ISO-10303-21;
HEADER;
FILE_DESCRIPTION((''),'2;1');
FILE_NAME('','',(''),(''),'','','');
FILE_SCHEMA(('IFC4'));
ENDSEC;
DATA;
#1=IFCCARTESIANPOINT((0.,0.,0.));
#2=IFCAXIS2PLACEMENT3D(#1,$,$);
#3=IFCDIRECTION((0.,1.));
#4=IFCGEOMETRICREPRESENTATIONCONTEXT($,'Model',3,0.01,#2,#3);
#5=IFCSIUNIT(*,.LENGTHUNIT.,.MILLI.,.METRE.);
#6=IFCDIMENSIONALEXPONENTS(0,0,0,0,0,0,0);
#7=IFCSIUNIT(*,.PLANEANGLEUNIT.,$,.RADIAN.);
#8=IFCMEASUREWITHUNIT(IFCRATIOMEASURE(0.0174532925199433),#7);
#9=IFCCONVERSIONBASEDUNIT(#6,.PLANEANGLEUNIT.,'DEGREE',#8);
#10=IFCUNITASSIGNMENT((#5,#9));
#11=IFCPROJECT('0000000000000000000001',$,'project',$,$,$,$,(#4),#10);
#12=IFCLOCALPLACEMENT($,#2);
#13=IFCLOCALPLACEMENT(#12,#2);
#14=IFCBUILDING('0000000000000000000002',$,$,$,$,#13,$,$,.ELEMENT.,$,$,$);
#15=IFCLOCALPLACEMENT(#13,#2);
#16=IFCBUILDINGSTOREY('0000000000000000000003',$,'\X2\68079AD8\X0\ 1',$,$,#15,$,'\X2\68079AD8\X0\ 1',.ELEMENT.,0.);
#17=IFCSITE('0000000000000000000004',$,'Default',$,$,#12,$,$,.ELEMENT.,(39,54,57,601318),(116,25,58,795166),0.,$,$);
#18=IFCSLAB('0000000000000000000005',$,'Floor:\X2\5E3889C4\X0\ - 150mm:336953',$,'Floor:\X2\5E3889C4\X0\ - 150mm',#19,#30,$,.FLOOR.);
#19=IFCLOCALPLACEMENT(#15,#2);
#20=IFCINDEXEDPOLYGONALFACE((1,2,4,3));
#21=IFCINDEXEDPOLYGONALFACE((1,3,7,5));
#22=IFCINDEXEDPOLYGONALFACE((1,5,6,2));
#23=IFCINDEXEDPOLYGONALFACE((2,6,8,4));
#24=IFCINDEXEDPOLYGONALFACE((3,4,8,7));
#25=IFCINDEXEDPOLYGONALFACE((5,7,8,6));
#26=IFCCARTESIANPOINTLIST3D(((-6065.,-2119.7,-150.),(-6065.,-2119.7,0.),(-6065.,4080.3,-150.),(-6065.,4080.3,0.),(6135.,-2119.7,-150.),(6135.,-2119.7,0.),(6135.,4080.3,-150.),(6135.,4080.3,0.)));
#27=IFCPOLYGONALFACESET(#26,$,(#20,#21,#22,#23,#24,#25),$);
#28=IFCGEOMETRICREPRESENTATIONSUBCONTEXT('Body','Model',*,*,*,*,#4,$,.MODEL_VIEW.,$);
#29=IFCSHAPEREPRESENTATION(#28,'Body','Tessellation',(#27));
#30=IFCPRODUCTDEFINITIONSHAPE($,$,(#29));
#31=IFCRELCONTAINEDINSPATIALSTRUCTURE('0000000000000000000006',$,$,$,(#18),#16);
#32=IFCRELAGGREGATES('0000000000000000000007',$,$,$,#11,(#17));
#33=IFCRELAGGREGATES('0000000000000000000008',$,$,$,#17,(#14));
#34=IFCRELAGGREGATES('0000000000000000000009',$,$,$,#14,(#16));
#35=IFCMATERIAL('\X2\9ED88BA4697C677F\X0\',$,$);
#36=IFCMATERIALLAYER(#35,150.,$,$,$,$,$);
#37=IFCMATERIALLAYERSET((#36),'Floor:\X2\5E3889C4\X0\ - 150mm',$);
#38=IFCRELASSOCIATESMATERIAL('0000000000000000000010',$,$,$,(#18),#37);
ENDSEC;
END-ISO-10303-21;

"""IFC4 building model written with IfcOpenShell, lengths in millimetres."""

from ifc_helpers import new_model, entity, si_unit, converted_unit, direction, frame, origin, origin_2d_with_axis, place, context, subcontext, project, spatial, rectangle, extrude, material, layer, layer_set, layer_usage, element, save


model = new_model("IFC4")

# Units and contexts
model_context = context("Model", 3, precision=0.01, world=origin(), true_north=direction((0.0, 1.0)))
body_context = subcontext(model_context, "Body", "Model", "MODEL_VIEW")
ifc_project = project(units=[si_unit("LENGTHUNIT", "METRE", prefix="MILLI"), converted_unit("PLANEANGLEUNIT", "DEGREE", entity("IfcRatioMeasure", 0.0174532925199433), si_unit("PLANEANGLEUNIT", "RADIAN"), dimensions=[0, 0, 0, 0, 0, 0, 0])], contexts=[model_context])

# Site, building, storey
site_placement = place(None, origin())
site = spatial("IfcSite", under=ifc_project, at=site_placement, Name="Default", CompositionType="ELEMENT", RefLatitude=(39, 54, 57, 601318), RefLongitude=(116, 25, 58, 795166), RefElevation=0.0)
building_placement = place(site_placement, origin())
building = spatial("IfcBuilding", under=site, at=building_placement, CompositionType="ELEMENT")
storey_placement = place(building_placement, origin())
storey = spatial("IfcBuildingStorey", under=building, at=storey_placement, Name="标高 1", LongName="标高 1", CompositionType="ELEMENT", Elevation=0.0)

# Slab
ifc_material = material(Name="默认楼板")
ifc_layer = layer(ifc_material, 150.0)
ifc_layer_set = layer_set([ifc_layer], Name="Floor:常规 - 150mm")
ifc_layer_usage = layer_usage(ifc_layer_set, "AXIS3", "POSITIVE", 0.0)
slab_placement = place(storey_placement, origin())
element("IfcSlab", 1, at=slab_placement, inside=storey, material=ifc_layer_usage, Name="Floor:常规 - 150mm:336953", ObjectType="Floor:常规 - 150mm", PredefinedType="FLOOR", context=body_context, shape_type="SweptSolid", body=[
    extrude(rectangle(XDim=6200.0, YDim=12200.0, at=origin_2d_with_axis()), frame((35.0, 980.3, 0.0), z_axis=(0.0, 0.0, -1.0), x_axis=(0.0, 1.0, 0.0)), (0.0, 0.0, 1.0), 150.0),
])

save(model, "model.ifc")
